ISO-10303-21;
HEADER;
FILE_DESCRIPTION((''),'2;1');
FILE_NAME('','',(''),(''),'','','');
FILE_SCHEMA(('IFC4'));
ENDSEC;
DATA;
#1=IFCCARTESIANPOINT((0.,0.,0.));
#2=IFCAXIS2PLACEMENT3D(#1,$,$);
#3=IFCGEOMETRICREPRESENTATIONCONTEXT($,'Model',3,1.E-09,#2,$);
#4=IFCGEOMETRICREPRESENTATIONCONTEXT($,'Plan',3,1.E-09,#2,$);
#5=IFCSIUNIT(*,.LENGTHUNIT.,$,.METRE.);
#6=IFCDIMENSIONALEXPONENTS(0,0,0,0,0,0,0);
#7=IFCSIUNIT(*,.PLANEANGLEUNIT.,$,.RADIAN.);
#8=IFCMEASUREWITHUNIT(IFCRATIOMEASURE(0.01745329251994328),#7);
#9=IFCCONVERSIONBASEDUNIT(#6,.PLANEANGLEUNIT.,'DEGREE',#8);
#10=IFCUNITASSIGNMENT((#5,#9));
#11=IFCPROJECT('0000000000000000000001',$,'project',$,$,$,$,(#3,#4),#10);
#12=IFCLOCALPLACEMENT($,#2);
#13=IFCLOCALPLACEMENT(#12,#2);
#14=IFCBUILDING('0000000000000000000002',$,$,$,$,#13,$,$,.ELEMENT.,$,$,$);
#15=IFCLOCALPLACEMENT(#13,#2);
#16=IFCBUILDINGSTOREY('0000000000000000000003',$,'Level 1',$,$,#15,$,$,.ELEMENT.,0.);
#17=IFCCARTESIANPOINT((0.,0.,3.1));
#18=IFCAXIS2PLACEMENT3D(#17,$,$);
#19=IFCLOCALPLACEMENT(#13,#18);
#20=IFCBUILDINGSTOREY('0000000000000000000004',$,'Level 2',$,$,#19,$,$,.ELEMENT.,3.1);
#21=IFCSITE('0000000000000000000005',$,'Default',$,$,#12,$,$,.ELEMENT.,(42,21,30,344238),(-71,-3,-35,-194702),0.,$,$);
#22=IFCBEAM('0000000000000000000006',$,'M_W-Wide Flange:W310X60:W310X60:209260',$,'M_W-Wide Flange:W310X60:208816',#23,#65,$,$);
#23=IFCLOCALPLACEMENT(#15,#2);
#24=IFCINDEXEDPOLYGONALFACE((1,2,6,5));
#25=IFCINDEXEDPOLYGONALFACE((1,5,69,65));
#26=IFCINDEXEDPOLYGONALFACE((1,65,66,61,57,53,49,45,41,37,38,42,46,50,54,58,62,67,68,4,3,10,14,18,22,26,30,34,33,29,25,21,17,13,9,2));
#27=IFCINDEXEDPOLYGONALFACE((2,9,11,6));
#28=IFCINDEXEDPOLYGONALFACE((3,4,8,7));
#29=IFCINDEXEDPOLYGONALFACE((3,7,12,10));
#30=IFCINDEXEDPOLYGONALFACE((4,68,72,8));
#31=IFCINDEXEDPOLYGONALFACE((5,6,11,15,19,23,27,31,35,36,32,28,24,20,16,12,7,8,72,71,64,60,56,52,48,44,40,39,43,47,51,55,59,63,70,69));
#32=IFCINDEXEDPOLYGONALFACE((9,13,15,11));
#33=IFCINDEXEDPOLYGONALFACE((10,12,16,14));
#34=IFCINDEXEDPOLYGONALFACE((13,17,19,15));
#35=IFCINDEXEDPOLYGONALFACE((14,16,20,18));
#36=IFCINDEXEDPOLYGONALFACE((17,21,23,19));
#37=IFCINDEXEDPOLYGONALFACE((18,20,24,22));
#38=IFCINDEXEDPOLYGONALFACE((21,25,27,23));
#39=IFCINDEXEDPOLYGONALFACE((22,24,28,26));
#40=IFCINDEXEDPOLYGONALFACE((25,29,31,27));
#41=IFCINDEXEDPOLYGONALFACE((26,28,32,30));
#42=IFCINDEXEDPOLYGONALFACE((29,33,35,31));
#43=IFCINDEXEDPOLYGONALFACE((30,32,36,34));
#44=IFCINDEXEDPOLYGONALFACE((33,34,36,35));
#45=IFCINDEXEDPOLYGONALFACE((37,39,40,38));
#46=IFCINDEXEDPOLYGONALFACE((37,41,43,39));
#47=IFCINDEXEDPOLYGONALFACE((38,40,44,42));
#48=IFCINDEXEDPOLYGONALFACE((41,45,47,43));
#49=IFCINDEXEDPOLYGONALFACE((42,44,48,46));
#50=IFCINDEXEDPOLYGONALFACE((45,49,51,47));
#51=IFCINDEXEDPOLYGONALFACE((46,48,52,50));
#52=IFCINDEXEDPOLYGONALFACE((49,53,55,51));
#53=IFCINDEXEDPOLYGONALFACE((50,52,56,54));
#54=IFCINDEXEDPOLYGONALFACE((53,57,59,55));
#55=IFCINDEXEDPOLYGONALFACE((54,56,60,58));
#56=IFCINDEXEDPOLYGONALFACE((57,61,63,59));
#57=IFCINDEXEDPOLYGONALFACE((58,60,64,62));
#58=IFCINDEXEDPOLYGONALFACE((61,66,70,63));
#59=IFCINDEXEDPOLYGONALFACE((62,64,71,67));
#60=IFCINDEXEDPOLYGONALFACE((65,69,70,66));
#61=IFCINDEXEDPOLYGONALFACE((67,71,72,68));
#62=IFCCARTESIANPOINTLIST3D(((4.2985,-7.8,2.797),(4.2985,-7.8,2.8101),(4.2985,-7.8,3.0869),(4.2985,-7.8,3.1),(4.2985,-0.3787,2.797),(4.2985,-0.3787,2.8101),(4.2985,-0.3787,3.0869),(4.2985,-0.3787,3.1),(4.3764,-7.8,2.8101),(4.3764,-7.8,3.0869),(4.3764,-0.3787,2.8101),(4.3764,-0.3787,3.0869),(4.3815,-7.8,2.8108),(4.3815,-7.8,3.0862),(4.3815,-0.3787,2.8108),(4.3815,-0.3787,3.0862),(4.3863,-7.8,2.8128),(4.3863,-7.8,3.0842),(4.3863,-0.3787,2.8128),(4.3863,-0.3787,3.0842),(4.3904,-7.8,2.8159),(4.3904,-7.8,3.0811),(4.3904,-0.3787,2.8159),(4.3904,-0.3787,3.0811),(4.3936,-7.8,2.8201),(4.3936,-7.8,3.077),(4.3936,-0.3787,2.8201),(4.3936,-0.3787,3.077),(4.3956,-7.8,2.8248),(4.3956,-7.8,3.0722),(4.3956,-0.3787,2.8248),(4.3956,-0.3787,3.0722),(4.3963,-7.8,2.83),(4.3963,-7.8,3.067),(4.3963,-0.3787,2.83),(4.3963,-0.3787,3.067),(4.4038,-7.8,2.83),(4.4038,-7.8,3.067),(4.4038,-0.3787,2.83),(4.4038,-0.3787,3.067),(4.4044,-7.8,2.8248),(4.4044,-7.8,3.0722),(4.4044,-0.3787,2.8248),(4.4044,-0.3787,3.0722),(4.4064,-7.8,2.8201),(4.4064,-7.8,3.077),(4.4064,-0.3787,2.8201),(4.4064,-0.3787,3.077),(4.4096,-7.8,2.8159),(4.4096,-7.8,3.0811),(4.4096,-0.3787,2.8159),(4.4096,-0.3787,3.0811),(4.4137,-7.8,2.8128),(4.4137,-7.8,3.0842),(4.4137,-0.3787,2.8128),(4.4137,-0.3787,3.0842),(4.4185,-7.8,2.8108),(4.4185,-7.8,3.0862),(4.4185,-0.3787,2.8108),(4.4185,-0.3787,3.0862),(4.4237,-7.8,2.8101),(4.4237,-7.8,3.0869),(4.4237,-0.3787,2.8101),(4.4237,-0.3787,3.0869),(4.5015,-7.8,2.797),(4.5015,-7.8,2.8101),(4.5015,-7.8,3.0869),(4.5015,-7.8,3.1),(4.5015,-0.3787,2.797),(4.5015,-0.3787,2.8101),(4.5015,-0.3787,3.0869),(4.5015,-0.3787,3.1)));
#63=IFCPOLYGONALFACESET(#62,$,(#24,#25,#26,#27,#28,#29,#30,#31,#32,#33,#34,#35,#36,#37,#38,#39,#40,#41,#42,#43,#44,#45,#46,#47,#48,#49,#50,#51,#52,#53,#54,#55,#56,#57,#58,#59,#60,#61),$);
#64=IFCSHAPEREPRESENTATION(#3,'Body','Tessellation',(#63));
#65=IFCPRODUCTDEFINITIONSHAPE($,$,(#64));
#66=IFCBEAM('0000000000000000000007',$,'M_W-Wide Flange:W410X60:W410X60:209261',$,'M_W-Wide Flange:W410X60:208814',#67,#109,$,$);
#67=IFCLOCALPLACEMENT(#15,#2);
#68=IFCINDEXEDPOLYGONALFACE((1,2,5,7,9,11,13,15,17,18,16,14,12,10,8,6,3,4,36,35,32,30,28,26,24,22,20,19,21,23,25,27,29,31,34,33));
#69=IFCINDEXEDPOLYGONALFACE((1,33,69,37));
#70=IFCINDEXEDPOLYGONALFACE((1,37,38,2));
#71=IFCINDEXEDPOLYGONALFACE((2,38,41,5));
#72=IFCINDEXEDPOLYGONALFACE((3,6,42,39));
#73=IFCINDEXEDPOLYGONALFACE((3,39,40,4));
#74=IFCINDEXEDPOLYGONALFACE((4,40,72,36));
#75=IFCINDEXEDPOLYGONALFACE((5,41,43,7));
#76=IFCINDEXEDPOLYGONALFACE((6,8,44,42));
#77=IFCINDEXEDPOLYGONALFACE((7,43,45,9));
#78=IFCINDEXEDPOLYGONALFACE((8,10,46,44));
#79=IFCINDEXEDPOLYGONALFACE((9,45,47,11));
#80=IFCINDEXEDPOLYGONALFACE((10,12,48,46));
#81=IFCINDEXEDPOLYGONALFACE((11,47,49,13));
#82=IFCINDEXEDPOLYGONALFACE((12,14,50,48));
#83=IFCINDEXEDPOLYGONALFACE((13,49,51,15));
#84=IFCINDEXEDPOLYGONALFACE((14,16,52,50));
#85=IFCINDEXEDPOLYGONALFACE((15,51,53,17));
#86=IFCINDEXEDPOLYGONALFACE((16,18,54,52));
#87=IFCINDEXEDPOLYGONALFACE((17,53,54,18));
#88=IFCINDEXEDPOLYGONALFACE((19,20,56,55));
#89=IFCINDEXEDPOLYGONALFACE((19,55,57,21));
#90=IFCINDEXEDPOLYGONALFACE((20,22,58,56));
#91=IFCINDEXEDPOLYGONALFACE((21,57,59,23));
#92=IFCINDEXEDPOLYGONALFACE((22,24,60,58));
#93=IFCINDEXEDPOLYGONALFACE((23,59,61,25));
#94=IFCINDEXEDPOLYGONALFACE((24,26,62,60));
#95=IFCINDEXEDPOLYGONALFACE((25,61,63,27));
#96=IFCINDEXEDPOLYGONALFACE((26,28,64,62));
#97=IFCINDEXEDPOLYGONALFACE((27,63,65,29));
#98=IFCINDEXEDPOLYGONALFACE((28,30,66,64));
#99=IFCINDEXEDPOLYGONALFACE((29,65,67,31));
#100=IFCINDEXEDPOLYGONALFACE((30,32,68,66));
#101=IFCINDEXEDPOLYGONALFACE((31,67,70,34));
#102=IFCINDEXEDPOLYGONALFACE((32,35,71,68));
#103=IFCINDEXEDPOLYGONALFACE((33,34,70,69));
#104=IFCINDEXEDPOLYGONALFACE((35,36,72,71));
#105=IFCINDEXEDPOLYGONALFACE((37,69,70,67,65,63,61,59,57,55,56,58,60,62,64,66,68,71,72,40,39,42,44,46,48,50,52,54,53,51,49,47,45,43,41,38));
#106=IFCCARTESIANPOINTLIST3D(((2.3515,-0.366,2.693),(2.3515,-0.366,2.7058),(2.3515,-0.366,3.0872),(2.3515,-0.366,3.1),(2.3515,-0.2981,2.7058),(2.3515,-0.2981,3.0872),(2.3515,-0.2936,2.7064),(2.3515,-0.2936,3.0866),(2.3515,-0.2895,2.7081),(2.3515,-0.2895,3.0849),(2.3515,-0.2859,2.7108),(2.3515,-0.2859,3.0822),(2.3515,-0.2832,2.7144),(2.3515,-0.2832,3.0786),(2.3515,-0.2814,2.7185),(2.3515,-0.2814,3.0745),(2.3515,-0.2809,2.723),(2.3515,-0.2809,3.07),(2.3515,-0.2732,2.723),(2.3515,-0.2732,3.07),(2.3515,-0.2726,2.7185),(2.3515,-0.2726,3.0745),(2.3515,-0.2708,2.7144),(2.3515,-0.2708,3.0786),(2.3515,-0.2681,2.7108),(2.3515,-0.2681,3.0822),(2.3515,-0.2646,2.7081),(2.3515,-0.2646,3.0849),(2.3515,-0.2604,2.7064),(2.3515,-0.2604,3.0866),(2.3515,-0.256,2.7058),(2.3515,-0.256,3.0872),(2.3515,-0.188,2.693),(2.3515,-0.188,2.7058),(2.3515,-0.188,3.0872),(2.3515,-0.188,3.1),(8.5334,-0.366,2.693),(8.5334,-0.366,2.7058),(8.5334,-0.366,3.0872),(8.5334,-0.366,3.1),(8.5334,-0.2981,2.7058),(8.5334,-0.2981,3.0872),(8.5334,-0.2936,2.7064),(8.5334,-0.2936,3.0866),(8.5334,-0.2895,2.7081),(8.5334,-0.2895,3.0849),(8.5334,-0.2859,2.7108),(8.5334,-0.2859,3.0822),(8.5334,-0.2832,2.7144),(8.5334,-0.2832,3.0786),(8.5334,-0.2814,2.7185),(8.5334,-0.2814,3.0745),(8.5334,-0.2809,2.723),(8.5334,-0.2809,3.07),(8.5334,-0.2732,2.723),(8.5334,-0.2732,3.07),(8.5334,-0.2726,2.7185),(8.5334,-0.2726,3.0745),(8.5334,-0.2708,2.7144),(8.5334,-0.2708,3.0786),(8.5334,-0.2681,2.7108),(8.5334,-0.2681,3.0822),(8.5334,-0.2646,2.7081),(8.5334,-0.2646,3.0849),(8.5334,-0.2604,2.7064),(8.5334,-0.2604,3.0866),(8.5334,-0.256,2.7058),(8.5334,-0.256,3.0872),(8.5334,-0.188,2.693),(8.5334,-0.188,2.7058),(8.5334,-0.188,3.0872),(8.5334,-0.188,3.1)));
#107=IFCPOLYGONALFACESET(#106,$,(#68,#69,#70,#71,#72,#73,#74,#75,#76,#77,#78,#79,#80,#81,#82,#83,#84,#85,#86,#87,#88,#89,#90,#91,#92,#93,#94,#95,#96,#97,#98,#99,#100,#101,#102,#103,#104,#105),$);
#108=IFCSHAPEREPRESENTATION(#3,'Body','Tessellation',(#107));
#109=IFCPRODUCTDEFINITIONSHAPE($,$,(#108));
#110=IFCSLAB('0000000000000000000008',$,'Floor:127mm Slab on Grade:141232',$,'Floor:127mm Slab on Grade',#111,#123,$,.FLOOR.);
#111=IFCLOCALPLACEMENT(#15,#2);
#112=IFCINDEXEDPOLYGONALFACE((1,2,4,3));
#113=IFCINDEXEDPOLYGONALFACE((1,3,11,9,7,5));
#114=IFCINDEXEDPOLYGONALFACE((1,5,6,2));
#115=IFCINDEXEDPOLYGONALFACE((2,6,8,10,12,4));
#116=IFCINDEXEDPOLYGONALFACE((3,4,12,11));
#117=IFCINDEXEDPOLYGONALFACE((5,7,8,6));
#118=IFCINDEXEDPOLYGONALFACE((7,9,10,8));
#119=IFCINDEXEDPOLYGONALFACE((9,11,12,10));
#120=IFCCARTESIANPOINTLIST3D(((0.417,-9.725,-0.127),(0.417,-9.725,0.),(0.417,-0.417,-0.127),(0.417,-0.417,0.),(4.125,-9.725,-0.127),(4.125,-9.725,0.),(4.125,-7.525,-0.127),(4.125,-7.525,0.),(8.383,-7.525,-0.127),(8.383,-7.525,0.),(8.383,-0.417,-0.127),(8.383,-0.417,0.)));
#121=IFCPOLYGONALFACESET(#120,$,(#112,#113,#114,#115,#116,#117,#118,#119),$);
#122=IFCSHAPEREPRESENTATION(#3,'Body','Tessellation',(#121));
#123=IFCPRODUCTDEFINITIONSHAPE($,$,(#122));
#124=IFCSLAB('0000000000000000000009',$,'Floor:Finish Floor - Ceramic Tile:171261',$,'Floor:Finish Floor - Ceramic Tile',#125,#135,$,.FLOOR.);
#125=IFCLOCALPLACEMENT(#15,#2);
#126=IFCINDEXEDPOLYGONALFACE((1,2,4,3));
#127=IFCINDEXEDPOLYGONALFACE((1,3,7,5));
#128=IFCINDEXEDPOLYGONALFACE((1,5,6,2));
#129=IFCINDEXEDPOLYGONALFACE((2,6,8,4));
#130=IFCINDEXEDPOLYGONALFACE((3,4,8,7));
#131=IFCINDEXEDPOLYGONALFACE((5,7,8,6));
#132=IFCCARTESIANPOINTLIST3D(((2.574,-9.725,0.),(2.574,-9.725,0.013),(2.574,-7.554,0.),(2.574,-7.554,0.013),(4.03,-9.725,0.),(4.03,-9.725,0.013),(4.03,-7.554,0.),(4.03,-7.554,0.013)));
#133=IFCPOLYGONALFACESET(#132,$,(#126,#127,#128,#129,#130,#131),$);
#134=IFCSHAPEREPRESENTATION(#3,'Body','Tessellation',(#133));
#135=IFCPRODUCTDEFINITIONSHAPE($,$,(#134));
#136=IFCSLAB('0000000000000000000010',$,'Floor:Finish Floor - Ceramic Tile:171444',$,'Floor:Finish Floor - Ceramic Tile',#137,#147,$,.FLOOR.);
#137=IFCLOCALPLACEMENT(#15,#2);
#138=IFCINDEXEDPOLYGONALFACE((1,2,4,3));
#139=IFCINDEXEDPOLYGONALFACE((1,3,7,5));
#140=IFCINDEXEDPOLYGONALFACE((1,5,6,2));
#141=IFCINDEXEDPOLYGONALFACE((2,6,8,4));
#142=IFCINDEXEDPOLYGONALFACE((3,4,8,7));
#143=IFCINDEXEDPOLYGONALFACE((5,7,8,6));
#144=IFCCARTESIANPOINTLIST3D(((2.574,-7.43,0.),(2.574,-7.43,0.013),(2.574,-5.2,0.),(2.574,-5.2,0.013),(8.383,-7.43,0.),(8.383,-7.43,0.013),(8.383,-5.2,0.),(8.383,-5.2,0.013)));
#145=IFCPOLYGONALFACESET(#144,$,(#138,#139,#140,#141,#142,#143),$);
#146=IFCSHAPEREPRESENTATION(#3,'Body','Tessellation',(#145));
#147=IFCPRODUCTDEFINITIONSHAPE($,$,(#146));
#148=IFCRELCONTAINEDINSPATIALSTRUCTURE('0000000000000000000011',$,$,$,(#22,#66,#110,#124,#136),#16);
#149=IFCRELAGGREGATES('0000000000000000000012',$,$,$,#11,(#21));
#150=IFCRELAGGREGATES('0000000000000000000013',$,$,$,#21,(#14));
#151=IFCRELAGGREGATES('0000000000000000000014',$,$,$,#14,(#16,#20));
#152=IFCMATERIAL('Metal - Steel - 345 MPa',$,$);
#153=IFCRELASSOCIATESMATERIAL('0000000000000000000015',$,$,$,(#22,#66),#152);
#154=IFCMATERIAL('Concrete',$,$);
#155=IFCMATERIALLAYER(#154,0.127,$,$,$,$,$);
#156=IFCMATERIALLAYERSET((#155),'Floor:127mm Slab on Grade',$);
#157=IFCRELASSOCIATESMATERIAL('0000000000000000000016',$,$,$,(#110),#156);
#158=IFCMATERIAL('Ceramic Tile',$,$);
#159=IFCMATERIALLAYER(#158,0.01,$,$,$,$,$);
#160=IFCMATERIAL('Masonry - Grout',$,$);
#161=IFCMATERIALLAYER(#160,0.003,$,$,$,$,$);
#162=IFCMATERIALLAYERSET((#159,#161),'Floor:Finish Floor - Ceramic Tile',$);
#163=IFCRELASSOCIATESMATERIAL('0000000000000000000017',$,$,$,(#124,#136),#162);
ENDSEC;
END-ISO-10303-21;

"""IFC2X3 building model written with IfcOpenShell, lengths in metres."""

from ifc_helpers import new_model, entity, si_unit, converted_unit, frame, frame_2d, origin, place, context, project, spatial, polyline, circle_curve, parameter, trimmed, segment, composite_curve, rectangle, outline, extrude, material, layer, layer_set, layer_usage, element, save


model = new_model("IFC2X3")

# Units and contexts
model_context = context("Model", 3, precision=1e-09, world=origin())
plan_context = context("Plan", 3, precision=1e-09, world=origin())
ifc_project = project(units=[si_unit("LENGTHUNIT", "METRE"), converted_unit("PLANEANGLEUNIT", "DEGREE", entity("IfcRatioMeasure", 0.01745329251994328), si_unit("PLANEANGLEUNIT", "RADIAN"), dimensions=[0, 0, 0, 0, 0, 0, 0])], contexts=[model_context, plan_context])

# Site, building, storey
site_placement = place(None, origin())
site = spatial("IfcSite", under=ifc_project, at=site_placement, Name="Default", CompositionType="ELEMENT", RefLatitude=(42, 21, 30, 344238), RefLongitude=(-71, -3, -35, -194702), RefElevation=0.0)
building_placement = place(site_placement, origin())
building = spatial("IfcBuilding", under=site, at=building_placement, CompositionType="ELEMENT")
storey_1_placement = place(building_placement, origin())
storey_1 = spatial("IfcBuildingStorey", under=building, at=storey_1_placement, Name="Level 1", CompositionType="ELEMENT", Elevation=0.0)

# Beams
ifc_material_1 = material(Name="Metal - Steel - 345 MPa")
beam_1_placement = place(storey_1_placement, frame((4.4, -7.8, 3.1)))
element("IfcBeam", 1, at=beam_1_placement, inside=storey_1, material=ifc_material_1, Name="M_W-Wide Flange:W310X60:W310X60:209260", ObjectType="M_W-Wide Flange:W310X60:208816", context=model_context, shape_type="SweptSolid", body=[
    extrude(outline(composite_curve([segment(polyline([(-0.1015, -0.1384), (-0.1015, -0.1515)]), True, "CONTINUOUS"), segment(polyline([(-0.1015, -0.1515), (0.1015, -0.1515)]), True, "CONTINUOUS"), segment(polyline([(0.1015, -0.1515), (0.1015, -0.1384)]), True, "CONTINUOUS"), segment(polyline([(0.1015, -0.1384), (0.0236, -0.1384)]), True, "CONTINUOUS"), segment(trimmed(circle_curve(frame_2d((0.0236, -0.1185), x_axis=(1.0, 0.0)), 0.0199), [parameter(180.0)], [parameter(270.0)], True, "PARAMETER"), False, "CONTINUOUS"), segment(polyline([(0.0037, -0.1185), (0.0037, 0.1185)]), True, "CONTINUOUS"), segment(trimmed(circle_curve(frame_2d((0.0236, 0.1185), x_axis=(1.0, 0.0)), 0.0199), [parameter(90.0)], [parameter(180.0)], True, "PARAMETER"), False, "CONTINUOUS"), segment(polyline([(0.0236, 0.1384), (0.1015, 0.1384)]), True, "CONTINUOUS"), segment(polyline([(0.1015, 0.1384), (0.1015, 0.1515)]), True, "CONTINUOUS"), segment(polyline([(0.1015, 0.1515), (-0.1015, 0.1515)]), True, "CONTINUOUS"), segment(polyline([(-0.1015, 0.1515), (-0.1015, 0.1384)]), True, "CONTINUOUS"), segment(polyline([(-0.1015, 0.1384), (-0.0237, 0.1384)]), True, "CONTINUOUS"), segment(trimmed(circle_curve(frame_2d((-0.0237, 0.1185), x_axis=(1.0, 0.0)), 0.0199), [parameter(360.0)], [parameter(90.0)], True, "PARAMETER"), False, "CONTINUOUS"), segment(polyline([(-0.0038, 0.1185), (-0.0038, -0.1185)]), True, "CONTINUOUS"), segment(trimmed(circle_curve(frame_2d((-0.0237, -0.1185), x_axis=(1.0, 0.0)), 0.0199), [parameter(270.0)], [parameter(0.0)], True, "PARAMETER"), False, "CONTINUOUS"), segment(polyline([(-0.0237, -0.1384), (-0.1015, -0.1384)]), True, "CONTINUOUS")], self_intersect=False)), frame((0.0, 0.0, -0.1515), z_axis=(0.0, -1.0, 0.0), x_axis=(1.0, 0.0, 0.0)), (0.0, 0.0, -1.0), 7.4213),
])
beam_2_placement = place(storey_1_placement, frame((8.5915, -0.277, 3.1), z_axis=(0.0, 0.0, 1.0), x_axis=(0.0, 1.0, 0.0)))
element("IfcBeam", 2, at=beam_2_placement, inside=storey_1, material=ifc_material_1, Name="M_W-Wide Flange:W410X60:W410X60:209261", ObjectType="M_W-Wide Flange:W410X60:208814", context=model_context, shape_type="SweptSolid", body=[
    extrude(outline(composite_curve([segment(polyline([(0.1907, -0.089), (0.2035, -0.089)]), True, "CONTINUOUS"), segment(polyline([(0.2035, -0.089), (0.2035, 0.089)]), True, "CONTINUOUS"), segment(polyline([(0.2035, 0.089), (0.1907, 0.089)]), True, "CONTINUOUS"), segment(polyline([(0.1907, 0.089), (0.1907, 0.021)]), True, "CONTINUOUS"), segment(trimmed(circle_curve(frame_2d((0.1735, 0.021), x_axis=(1.0, 0.0)), 0.0172), [parameter(270.0)], [parameter(360.0)], True, "PARAMETER"), False, "CONTINUOUS"), segment(polyline([(0.1735, 0.0038), (-0.1735, 0.0038)]), True, "CONTINUOUS"), segment(trimmed(circle_curve(frame_2d((-0.1735, 0.021), x_axis=(0.0, -1.0)), 0.0172), [parameter(270.0)], [parameter(360.0)], True, "PARAMETER"), False, "CONTINUOUS"), segment(polyline([(-0.1907, 0.021), (-0.1907, 0.089)]), True, "CONTINUOUS"), segment(polyline([(-0.1907, 0.089), (-0.2035, 0.089)]), True, "CONTINUOUS"), segment(polyline([(-0.2035, 0.089), (-0.2035, -0.089)]), True, "CONTINUOUS"), segment(polyline([(-0.2035, -0.089), (-0.1907, -0.089)]), True, "CONTINUOUS"), segment(polyline([(-0.1907, -0.089), (-0.1907, -0.0211)]), True, "CONTINUOUS"), segment(trimmed(circle_curve(frame_2d((-0.1735, -0.0211), x_axis=(-1.0, 0.0)), 0.0172), [parameter(270.0)], [parameter(0.0)], True, "PARAMETER"), False, "CONTINUOUS"), segment(polyline([(-0.1735, -0.0039), (0.1735, -0.0039)]), True, "CONTINUOUS"), segment(trimmed(circle_curve(frame_2d((0.1735, -0.0211), x_axis=(0.0, 1.0)), 0.0172), [parameter(270.0)], [parameter(0.0)], True, "PARAMETER"), False, "CONTINUOUS"), segment(polyline([(0.1907, -0.0211), (0.1907, -0.089)]), True, "CONTINUOUS")], self_intersect=False)), frame((0.0, 6.24, -0.2035), z_axis=(0.0, -1.0, 0.0), x_axis=(0.0, 0.0, -1.0)), (0.0, 0.0, 1.0), 6.1819),
])

# Slabs
ifc_material_2 = material(Name="Concrete")
ifc_layer_1 = layer(ifc_material_2, 0.127)
ifc_layer_set_1 = layer_set([ifc_layer_1], Name="Floor:127mm Slab on Grade")
ifc_layer_usage_1 = layer_usage(ifc_layer_set_1, "AXIS3", "POSITIVE", 0.0)
slab_1_placement = place(storey_1_placement, frame((0.417, -9.725, -0.127)))
element("IfcSlab", 3, at=slab_1_placement, inside=storey_1, material=ifc_layer_usage_1, Name="Floor:127mm Slab on Grade:141232", ObjectType="Floor:127mm Slab on Grade", PredefinedType="FLOOR", context=model_context, shape_type="SweptSolid", body=[
    extrude(outline(polyline([(-3.983, 4.654), (-3.983, -2.454), (0.275, -2.454), (0.275, -4.654), (3.983, -4.654), (3.983, 4.654), (-3.983, 4.654)])), frame((3.983, 4.654, 0.127), z_axis=(0.0, 0.0, -1.0), x_axis=(-1.0, 0.0, 0.0)), (0.0, 0.0, 1.0), 0.127),
])
ifc_material_3 = material(Name="Ceramic Tile")
ifc_layer_2 = layer(ifc_material_3, 0.01)
ifc_material_4 = material(Name="Masonry - Grout")
ifc_layer_3 = layer(ifc_material_4, 0.003)
ifc_layer_set_2 = layer_set([ifc_layer_2, ifc_layer_3], Name="Floor:Finish Floor - Ceramic Tile")
ifc_layer_usage_2 = layer_usage(ifc_layer_set_2, "AXIS3", "POSITIVE", 0.0)
slab_2_placement = place(storey_1_placement, frame((2.574, -9.725, 0.0)))
element("IfcSlab", 4, at=slab_2_placement, inside=storey_1, material=ifc_layer_usage_2, Name="Floor:Finish Floor - Ceramic Tile:171261", ObjectType="Floor:Finish Floor - Ceramic Tile", PredefinedType="FLOOR", context=model_context, shape_type="SweptSolid", body=[
    extrude(rectangle(XDim=2.171, YDim=1.456, at=frame_2d((0.0, 0.0), x_axis=(0.0, -1.0))), frame((0.728, 1.0855, 0.013), z_axis=(0.0, 0.0, -1.0), x_axis=(-1.0, 0.0, 0.0)), (0.0, 0.0, 1.0), 0.013),
])
ifc_layer_usage_3 = layer_usage(ifc_layer_set_2, "AXIS3", "POSITIVE", 0.0)
slab_3_placement = place(storey_1_placement, frame((2.574, -7.43, 0.0)))
element("IfcSlab", 5, at=slab_3_placement, inside=storey_1, material=ifc_layer_usage_3, Name="Floor:Finish Floor - Ceramic Tile:171444", ObjectType="Floor:Finish Floor - Ceramic Tile", PredefinedType="FLOOR", context=model_context, shape_type="SweptSolid", body=[
    extrude(rectangle(XDim=5.809, YDim=2.23, at=frame_2d((0.0, 0.0), x_axis=(-1.0, 0.0))), frame((2.9045, 1.115, 0.013), z_axis=(0.0, 0.0, -1.0), x_axis=(-1.0, 0.0, 0.0)), (0.0, 0.0, 1.0), 0.013),
])

# Shared definitions
storey_2_placement = place(building_placement, frame((0.0, 0.0, 3.1)))
storey_2 = spatial("IfcBuildingStorey", under=building, at=storey_2_placement, Name="Level 2", CompositionType="ELEMENT", Elevation=3.1)

save(model, "model.ifc")
